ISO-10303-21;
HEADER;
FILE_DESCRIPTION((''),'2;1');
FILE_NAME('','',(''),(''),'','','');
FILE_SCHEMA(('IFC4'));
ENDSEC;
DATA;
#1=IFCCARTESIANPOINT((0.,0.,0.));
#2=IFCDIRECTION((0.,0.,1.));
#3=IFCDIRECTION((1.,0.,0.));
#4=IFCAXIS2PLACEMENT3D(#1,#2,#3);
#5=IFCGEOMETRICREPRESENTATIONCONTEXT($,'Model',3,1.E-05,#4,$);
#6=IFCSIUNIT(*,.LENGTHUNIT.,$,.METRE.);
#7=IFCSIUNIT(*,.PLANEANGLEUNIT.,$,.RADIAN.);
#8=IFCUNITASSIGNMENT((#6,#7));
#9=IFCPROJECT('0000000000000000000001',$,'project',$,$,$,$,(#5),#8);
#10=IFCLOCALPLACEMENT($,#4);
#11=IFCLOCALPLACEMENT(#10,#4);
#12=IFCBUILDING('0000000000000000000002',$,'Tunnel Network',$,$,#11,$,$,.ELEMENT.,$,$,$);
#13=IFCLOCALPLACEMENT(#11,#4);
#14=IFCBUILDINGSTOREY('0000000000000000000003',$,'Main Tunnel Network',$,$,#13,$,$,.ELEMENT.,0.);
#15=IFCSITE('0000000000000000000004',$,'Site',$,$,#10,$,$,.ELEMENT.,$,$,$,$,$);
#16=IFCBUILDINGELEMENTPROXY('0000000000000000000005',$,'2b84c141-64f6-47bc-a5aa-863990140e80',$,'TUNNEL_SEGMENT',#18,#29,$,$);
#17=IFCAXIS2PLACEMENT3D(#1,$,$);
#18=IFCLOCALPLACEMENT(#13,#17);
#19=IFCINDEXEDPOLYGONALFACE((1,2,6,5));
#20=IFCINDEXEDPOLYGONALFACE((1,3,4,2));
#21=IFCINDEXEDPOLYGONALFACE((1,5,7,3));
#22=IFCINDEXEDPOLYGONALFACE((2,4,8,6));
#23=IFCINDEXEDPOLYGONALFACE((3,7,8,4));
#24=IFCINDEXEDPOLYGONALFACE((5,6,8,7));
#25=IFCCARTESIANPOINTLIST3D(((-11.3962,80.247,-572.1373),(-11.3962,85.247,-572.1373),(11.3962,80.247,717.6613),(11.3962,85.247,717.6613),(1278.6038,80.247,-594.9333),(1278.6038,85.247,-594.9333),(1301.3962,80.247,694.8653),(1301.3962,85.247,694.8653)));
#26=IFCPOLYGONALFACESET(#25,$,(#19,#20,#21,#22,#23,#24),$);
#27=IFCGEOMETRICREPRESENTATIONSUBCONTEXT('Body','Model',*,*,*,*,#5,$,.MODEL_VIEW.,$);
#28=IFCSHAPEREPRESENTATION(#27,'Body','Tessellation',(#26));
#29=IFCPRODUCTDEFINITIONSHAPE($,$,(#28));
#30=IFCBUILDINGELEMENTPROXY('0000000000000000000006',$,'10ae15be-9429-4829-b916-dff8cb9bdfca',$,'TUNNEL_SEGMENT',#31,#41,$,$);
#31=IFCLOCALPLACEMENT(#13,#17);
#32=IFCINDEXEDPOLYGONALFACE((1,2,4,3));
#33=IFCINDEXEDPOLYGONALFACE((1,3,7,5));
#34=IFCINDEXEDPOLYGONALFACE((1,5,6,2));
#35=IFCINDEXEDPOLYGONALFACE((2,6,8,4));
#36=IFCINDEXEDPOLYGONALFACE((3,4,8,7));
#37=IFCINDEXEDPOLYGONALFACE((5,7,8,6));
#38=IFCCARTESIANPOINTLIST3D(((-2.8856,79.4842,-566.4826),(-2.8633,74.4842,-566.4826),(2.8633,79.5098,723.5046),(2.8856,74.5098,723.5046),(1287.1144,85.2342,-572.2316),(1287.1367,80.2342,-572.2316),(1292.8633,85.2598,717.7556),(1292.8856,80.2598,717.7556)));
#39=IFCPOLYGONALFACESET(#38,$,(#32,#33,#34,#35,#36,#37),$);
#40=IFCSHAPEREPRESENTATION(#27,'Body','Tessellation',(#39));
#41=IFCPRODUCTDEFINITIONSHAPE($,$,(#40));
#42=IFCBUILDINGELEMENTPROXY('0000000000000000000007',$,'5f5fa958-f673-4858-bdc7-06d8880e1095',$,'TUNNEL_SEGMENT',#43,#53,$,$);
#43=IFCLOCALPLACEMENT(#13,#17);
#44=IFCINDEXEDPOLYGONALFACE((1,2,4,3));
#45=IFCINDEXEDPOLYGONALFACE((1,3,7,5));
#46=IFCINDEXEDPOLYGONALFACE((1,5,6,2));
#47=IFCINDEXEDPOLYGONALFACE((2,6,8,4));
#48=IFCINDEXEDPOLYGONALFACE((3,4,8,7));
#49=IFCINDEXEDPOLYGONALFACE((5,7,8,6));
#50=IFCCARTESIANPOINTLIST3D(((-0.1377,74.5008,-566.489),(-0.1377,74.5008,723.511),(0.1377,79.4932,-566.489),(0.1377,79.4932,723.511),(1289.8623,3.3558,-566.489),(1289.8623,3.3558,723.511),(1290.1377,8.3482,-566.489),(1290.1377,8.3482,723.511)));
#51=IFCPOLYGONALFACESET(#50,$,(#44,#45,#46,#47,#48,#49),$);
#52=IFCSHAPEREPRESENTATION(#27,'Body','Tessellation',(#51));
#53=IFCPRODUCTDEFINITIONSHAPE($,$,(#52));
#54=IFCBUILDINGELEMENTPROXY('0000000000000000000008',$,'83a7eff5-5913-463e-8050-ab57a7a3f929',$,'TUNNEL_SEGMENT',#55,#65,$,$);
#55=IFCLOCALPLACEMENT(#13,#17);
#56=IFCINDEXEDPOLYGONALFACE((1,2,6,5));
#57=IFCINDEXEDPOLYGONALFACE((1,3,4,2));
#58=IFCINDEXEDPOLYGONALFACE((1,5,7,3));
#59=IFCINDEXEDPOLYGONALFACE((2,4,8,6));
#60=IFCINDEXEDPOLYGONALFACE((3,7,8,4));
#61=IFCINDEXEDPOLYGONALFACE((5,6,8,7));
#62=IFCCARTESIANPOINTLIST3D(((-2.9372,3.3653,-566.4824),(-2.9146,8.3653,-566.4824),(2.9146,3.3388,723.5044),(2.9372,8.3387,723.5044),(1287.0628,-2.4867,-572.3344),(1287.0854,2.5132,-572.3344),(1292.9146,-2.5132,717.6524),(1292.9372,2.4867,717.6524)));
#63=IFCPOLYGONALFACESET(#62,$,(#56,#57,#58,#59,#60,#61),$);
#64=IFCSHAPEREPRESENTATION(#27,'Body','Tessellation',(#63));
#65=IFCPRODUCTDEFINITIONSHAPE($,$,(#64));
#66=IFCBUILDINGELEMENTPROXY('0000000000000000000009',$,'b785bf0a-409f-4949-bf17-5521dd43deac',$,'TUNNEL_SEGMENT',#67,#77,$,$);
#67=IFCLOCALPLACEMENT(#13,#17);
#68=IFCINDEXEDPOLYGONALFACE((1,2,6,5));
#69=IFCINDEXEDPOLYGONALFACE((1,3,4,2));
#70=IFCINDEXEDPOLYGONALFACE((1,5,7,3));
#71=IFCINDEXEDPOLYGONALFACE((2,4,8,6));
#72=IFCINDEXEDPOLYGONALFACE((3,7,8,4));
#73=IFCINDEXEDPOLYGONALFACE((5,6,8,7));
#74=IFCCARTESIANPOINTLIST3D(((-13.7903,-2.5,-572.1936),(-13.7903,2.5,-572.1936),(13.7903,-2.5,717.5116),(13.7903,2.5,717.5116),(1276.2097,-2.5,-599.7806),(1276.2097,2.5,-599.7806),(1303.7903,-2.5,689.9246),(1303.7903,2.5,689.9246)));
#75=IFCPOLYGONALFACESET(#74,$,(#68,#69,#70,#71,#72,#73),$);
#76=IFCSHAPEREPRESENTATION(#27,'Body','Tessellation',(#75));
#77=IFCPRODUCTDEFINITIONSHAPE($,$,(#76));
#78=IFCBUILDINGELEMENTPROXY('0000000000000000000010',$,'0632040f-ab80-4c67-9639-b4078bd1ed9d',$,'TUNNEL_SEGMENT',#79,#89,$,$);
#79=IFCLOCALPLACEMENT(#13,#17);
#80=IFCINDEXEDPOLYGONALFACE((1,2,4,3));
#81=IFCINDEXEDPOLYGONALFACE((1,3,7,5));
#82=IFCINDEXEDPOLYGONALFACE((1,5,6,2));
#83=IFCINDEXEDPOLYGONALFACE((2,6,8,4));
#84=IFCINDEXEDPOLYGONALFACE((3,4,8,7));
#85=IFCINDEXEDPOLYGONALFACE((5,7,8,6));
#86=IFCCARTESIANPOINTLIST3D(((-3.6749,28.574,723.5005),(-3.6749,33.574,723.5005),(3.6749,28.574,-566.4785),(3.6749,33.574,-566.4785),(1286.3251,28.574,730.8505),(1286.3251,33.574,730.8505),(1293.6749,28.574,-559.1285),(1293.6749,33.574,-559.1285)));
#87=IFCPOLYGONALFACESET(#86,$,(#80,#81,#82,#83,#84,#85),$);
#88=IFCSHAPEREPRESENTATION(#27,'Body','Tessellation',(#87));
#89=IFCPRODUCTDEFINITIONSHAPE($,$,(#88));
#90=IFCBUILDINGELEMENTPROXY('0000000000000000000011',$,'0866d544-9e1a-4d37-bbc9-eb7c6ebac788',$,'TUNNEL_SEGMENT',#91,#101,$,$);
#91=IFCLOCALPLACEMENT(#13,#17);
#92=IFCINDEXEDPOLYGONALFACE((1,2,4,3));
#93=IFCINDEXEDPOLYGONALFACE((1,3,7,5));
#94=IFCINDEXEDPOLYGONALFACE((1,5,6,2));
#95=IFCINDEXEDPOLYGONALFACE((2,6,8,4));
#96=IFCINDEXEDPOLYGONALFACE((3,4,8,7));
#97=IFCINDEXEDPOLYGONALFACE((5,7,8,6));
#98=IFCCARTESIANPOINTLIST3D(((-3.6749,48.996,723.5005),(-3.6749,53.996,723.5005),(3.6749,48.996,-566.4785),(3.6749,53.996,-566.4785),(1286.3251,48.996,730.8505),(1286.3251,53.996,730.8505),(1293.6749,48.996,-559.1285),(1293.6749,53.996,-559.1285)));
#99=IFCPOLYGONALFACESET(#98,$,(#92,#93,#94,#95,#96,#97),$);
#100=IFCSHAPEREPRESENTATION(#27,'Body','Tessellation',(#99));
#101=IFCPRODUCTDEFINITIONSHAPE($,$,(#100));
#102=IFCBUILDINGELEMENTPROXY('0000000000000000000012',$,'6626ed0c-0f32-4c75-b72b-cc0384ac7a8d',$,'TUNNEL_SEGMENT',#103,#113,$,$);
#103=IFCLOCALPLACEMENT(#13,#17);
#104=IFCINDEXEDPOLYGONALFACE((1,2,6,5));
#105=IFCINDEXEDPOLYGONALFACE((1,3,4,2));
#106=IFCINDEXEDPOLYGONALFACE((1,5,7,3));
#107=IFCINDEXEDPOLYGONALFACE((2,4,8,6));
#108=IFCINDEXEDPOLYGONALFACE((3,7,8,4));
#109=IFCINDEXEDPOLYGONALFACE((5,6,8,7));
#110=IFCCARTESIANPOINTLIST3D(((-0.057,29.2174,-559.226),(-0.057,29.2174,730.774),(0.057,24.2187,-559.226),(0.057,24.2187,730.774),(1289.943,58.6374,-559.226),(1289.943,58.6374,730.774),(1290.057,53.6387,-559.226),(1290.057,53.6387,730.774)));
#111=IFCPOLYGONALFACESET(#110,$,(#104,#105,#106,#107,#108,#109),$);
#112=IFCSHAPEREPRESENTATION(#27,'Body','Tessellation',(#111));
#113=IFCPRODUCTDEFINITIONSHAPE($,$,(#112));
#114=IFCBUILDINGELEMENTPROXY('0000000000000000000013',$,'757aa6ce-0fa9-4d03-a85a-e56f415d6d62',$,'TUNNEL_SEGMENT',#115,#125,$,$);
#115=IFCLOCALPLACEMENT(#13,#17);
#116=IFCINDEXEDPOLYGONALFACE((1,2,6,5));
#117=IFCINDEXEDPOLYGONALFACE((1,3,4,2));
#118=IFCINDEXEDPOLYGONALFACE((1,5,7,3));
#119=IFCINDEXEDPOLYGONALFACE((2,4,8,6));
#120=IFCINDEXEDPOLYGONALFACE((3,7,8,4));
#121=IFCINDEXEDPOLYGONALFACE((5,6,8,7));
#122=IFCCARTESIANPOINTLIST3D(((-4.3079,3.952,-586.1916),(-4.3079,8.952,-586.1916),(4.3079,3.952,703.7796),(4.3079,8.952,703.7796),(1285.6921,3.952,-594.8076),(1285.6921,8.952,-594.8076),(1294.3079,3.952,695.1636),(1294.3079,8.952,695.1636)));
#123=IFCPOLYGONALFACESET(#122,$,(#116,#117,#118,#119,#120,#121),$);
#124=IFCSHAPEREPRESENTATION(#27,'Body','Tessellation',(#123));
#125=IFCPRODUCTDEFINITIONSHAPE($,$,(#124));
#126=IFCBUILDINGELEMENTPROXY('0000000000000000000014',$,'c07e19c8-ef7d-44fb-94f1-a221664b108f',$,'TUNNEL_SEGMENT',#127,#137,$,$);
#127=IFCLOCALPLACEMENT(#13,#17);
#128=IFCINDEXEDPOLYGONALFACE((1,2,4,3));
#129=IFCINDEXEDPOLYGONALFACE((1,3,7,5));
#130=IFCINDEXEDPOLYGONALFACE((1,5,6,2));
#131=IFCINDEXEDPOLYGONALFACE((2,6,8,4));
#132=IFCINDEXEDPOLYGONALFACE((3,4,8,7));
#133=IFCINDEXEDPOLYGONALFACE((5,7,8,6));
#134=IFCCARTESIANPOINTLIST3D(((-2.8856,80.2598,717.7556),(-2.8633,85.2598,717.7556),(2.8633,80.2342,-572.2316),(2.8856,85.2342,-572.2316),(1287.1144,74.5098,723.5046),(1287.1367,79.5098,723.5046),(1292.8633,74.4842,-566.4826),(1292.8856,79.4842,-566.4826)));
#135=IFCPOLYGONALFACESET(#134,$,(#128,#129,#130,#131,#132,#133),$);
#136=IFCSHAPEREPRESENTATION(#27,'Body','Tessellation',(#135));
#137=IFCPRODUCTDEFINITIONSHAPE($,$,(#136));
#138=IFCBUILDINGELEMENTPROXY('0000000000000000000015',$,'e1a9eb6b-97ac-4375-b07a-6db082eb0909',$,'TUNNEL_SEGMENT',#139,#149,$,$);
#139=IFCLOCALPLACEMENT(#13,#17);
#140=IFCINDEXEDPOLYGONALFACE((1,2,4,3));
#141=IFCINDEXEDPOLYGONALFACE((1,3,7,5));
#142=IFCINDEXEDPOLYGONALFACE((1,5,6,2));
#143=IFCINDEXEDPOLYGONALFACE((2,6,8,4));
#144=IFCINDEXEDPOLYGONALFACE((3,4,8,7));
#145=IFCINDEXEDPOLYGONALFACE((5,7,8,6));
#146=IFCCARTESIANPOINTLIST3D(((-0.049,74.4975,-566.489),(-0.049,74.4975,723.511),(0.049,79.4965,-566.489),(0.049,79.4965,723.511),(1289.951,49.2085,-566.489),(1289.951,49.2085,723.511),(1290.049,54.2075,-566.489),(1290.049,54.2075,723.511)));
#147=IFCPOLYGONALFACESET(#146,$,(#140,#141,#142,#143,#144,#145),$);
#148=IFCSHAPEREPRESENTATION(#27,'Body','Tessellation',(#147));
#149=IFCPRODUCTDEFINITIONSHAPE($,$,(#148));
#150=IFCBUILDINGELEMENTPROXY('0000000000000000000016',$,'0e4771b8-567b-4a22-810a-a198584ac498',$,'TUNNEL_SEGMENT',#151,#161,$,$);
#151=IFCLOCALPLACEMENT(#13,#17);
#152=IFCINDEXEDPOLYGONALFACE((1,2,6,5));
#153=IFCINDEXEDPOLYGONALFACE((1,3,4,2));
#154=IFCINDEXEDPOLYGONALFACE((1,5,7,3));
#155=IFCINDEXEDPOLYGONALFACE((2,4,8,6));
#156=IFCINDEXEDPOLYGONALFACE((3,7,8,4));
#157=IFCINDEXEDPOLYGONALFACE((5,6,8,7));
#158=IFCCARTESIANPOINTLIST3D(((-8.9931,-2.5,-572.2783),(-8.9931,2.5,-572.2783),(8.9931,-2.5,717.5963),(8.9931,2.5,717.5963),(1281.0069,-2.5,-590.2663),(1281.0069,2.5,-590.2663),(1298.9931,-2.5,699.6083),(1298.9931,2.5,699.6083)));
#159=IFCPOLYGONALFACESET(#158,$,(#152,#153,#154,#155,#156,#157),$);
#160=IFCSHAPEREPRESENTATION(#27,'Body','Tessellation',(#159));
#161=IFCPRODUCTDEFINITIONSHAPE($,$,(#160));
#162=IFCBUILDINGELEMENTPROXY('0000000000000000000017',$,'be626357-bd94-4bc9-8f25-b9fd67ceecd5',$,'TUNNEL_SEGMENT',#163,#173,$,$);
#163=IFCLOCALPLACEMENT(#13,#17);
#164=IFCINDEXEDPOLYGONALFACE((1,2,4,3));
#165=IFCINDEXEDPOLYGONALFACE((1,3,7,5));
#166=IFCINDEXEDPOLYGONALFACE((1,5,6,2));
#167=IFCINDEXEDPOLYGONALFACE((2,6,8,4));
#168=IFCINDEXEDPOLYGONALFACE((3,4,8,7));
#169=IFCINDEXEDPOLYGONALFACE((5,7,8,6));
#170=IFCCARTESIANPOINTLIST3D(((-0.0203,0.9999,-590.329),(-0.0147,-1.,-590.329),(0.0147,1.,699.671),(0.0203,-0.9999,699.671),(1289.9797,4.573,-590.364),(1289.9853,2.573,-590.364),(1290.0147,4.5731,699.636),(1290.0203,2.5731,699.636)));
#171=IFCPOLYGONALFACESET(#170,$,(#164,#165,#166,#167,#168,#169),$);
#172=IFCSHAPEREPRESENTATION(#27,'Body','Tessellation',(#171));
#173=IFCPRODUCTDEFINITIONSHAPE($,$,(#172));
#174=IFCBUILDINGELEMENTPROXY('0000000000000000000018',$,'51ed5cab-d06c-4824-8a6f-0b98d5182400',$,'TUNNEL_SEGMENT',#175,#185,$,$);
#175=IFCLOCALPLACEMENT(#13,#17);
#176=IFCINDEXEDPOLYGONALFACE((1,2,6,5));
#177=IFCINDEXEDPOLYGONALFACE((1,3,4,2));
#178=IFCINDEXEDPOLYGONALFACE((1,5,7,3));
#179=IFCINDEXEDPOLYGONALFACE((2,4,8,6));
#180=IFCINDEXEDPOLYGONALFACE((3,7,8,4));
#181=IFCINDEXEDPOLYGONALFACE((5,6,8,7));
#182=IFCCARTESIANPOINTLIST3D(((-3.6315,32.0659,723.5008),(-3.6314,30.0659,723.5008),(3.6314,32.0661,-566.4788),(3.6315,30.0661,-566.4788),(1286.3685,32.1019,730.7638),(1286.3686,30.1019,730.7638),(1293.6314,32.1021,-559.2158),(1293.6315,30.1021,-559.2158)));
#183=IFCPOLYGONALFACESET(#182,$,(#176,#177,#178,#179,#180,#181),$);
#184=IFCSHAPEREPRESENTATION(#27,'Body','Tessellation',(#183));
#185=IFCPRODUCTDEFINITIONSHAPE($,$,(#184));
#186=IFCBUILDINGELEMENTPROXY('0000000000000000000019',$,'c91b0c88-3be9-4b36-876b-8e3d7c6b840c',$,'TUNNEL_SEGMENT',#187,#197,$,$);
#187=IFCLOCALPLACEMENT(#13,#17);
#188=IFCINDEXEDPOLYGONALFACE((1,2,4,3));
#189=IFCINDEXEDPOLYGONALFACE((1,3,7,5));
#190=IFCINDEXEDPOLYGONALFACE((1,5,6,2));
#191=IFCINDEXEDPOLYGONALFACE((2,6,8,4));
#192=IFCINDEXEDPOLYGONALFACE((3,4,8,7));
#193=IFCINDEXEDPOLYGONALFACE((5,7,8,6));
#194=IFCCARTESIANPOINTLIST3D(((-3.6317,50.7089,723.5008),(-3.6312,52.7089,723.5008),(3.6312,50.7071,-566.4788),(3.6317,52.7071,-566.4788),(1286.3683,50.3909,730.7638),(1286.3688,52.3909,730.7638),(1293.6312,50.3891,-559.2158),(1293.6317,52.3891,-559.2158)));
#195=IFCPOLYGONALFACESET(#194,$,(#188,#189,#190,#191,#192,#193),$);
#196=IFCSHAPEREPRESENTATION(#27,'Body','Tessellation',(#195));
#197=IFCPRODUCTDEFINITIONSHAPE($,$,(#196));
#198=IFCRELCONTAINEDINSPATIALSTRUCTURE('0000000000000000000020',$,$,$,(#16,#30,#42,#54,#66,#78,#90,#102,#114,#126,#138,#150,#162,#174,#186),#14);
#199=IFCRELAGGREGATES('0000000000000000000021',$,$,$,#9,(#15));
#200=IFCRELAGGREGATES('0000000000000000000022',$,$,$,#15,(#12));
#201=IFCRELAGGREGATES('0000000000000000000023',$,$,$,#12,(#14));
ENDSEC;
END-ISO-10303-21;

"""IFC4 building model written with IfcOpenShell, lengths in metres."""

from ifc_helpers import new_model, si_unit, frame, origin_with_axes, origin_2d_with_axis, place, context, subcontext, project, spatial, rectangle, extrude, element, save


model = new_model("IFC4")

# Units and contexts
model_context = context("Model", 3, precision=1e-05, world=origin_with_axes())
body_context = subcontext(model_context, "Body", "Model", "MODEL_VIEW")
ifc_project = project(units=[si_unit("LENGTHUNIT", "METRE"), si_unit("PLANEANGLEUNIT", "RADIAN")], contexts=[model_context])

# Site, building, storey
site_placement = place(None, origin_with_axes())
site = spatial("IfcSite", under=ifc_project, at=site_placement, Name="Site", CompositionType="ELEMENT")
building_placement = place(site_placement, origin_with_axes())
building = spatial("IfcBuilding", under=site, at=building_placement, Name="Tunnel Network", CompositionType="ELEMENT")
storey_placement = place(building_placement, origin_with_axes())
storey = spatial("IfcBuildingStorey", under=building, at=storey_placement, Name="Main Tunnel Network", CompositionType="ELEMENT", Elevation=0.0)

# Building element proxies
proxy_1_placement = place(storey_placement, frame((0.0, 82.747, 72.762), z_axis=(0.999844, 0.0, -0.017669), x_axis=(0.017669, 0.0, 0.999844)))
element("IfcBuildingElementProxy", 1, at=proxy_1_placement, inside=storey, Name="2b84c141-64f6-47bc-a5aa-863990140e80", ObjectType="TUNNEL_SEGMENT", context=body_context, shape_type="SweptSolid", body=[
    extrude(rectangle(XDim=1290.0, YDim=5.0, at=origin_2d_with_axis()), origin_with_axes(), (0.0, 0.0, 1.0), 1290.2014),
])
proxy_2_placement = place(storey_placement, frame((0.0, 76.997, 78.511), z_axis=(0.99998, 0.004457, -0.004457), x_axis=(0.004456, 0.00002, 0.99999)))
element("IfcBuildingElementProxy", 2, at=proxy_2_placement, inside=storey, Name="10ae15be-9429-4829-b916-dff8cb9bdfca", ObjectType="TUNNEL_SEGMENT", context=body_context, shape_type="SweptSolid", body=[
    extrude(rectangle(XDim=1290.0, YDim=5.0, at=origin_2d_with_axis()), origin_with_axes(), (0.0, 0.0, 1.0), 1290.0256),
])
proxy_3_placement = place(storey_placement, frame((0.0, 76.997, 78.511), z_axis=(0.998483, -0.055067, 0.0), x_axis=(0.0, 0.0, 1.0)))
element("IfcBuildingElementProxy", 3, at=proxy_3_placement, inside=storey, Name="5f5fa958-f673-4858-bdc7-06d8880e1095", ObjectType="TUNNEL_SEGMENT", context=body_context, shape_type="SweptSolid", body=[
    extrude(rectangle(XDim=1290.0, YDim=5.0, at=origin_2d_with_axis()), origin_with_axes(), (0.0, 0.0, 1.0), 1291.9604),
])
proxy_4_placement = place(storey_placement, frame((0.0, 5.852, 78.511), z_axis=(0.999979, -0.004536, -0.004536), x_axis=(0.004536, -0.000021, 0.99999)))
element("IfcBuildingElementProxy", 4, at=proxy_4_placement, inside=storey, Name="83a7eff5-5913-463e-8050-ab57a7a3f929", ObjectType="TUNNEL_SEGMENT", context=body_context, shape_type="SweptSolid", body=[
    extrude(rectangle(XDim=1290.0, YDim=5.0, at=origin_2d_with_axis()), origin_with_axes(), (0.0, 0.0, 1.0), 1290.0265),
])
proxy_5_placement = place(storey_placement, frame((0.0, 0.0, 72.659), z_axis=(0.999771, 0.0, -0.02138), x_axis=(0.02138, 0.0, 0.999771)))
element("IfcBuildingElementProxy", 5, at=proxy_5_placement, inside=storey, Name="b785bf0a-409f-4949-bf17-5521dd43deac", ObjectType="TUNNEL_SEGMENT", context=body_context, shape_type="SweptSolid", body=[
    extrude(rectangle(XDim=1290.0, YDim=5.0, at=origin_2d_with_axis()), origin_with_axes(), (0.0, 0.0, 1.0), 1290.2949),
])
for number, where, z_axis, x_axis, name in (
    (6, (0.0, 31.074, 78.511), (0.999984, 0.0, 0.005698), (-0.005698, 0.0, 0.999984), "0632040f-ab80-4c67-9639-b4078bd1ed9d"),
    (7, (0.0, 51.496, 78.511), (0.999984, 0.0, 0.005698), (-0.005698, 0.0, 0.999984), "0866d544-9e1a-4d37-bbc9-eb7c6ebac788"),
):
    element("IfcBuildingElementProxy", number, at=place(storey_placement, frame(where, z_axis=z_axis, x_axis=x_axis)), inside=storey, Name=name, ObjectType="TUNNEL_SEGMENT", context=body_context, shape_type="SweptSolid", body=[
        extrude(rectangle(XDim=1290.0, YDim=5.0, at=origin_2d_with_axis()), origin_with_axes(), (0.0, 0.0, 1.0), 1290.0209),
    ])
proxy_6_placement = place(storey_placement, frame((0.0, 26.718, 85.774), z_axis=(0.99974, 0.0228, 0.0), x_axis=(0.0, 0.0, 1.0)))
element("IfcBuildingElementProxy", 8, at=proxy_6_placement, inside=storey, Name="6626ed0c-0f32-4c75-b72b-cc0384ac7a8d", ObjectType="TUNNEL_SEGMENT", context=body_context, shape_type="SweptSolid", body=[
    extrude(rectangle(XDim=1290.0, YDim=5.0, at=origin_2d_with_axis()), origin_with_axes(), (0.0, 0.0, 1.0), 1290.3354),
])
proxy_7_placement = place(storey_placement, frame((0.0, 6.452, 58.794), z_axis=(0.999978, 0.0, -0.006679), x_axis=(0.006679, 0.0, 0.999978)))
element("IfcBuildingElementProxy", 9, at=proxy_7_placement, inside=storey, Name="757aa6ce-0fa9-4d03-a85a-e56f415d6d62", ObjectType="TUNNEL_SEGMENT", context=body_context, shape_type="SweptSolid", body=[
    extrude(rectangle(XDim=1290.0, YDim=5.0, at=origin_2d_with_axis()), origin_with_axes(), (0.0, 0.0, 1.0), 1290.0288),
])
proxy_8_placement = place(storey_placement, frame((0.0, 82.747, 72.762), z_axis=(0.99998, -0.004457, 0.004457), x_axis=(-0.004456, 0.00002, 0.99999)))
element("IfcBuildingElementProxy", 10, at=proxy_8_placement, inside=storey, Name="c07e19c8-ef7d-44fb-94f1-a221664b108f", ObjectType="TUNNEL_SEGMENT", context=body_context, shape_type="SweptSolid", body=[
    extrude(rectangle(XDim=1290.0, YDim=5.0, at=origin_2d_with_axis()), origin_with_axes(), (0.0, 0.0, 1.0), 1290.0256),
])
proxy_9_placement = place(storey_placement, frame((0.0, 76.997, 78.511), z_axis=(0.999808, -0.0196, 0.0), x_axis=(0.0, 0.0, 1.0)))
element("IfcBuildingElementProxy", 11, at=proxy_9_placement, inside=storey, Name="e1a9eb6b-97ac-4375-b07a-6db082eb0909", ObjectType="TUNNEL_SEGMENT", context=body_context, shape_type="SweptSolid", body=[
    extrude(rectangle(XDim=1290.0, YDim=5.0, at=origin_2d_with_axis()), origin_with_axes(), (0.0, 0.0, 1.0), 1290.2479),
])
proxy_10_placement = place(storey_placement, frame((0.0, 0.0, 72.659), z_axis=(0.999903, 0.0, -0.013943), x_axis=(0.013943, 0.0, 0.999903)))
element("IfcBuildingElementProxy", 12, at=proxy_10_placement, inside=storey, Name="0e4771b8-567b-4a22-810a-a198584ac498", ObjectType="TUNNEL_SEGMENT", context=body_context, shape_type="SweptSolid", body=[
    extrude(rectangle(XDim=1290.0, YDim=5.0, at=origin_2d_with_axis()), origin_with_axes(), (0.0, 0.0, 1.0), 1290.1254),
])
proxy_11_placement = place(storey_placement, frame((0.0, 0.0, 54.671), z_axis=(0.999996, 0.00277, -0.000027), x_axis=(0.000027, 0.0, 1.0)))
element("IfcBuildingElementProxy", 13, at=proxy_11_placement, inside=storey, Name="be626357-bd94-4bc9-8f25-b9fd67ceecd5", ObjectType="TUNNEL_SEGMENT", context=body_context, shape_type="SweptSolid", body=[
    extrude(rectangle(XDim=1290.0, YDim=2.0, at=origin_2d_with_axis()), origin_with_axes(), (0.0, 0.0, 1.0), 1290.0049),
])
proxy_12_placement = place(storey_placement, frame((0.0, 31.066, 78.511), z_axis=(0.999984, 0.000028, 0.00563), x_axis=(-0.00563, 0.0, 0.999984)))
element("IfcBuildingElementProxy", 14, at=proxy_12_placement, inside=storey, Name="51ed5cab-d06c-4824-8a6f-0b98d5182400", ObjectType="TUNNEL_SEGMENT", context=body_context, shape_type="SweptSolid", body=[
    extrude(rectangle(XDim=1290.0, YDim=2.0, at=origin_2d_with_axis()), origin_with_axes(), (0.0, 0.0, 1.0), 1290.0204),
])
proxy_13_placement = place(storey_placement, frame((0.0, 51.708, 78.511), z_axis=(0.999984, -0.000247, 0.00563), x_axis=(-0.00563, 0.000001, 0.999984)))
element("IfcBuildingElementProxy", 15, at=proxy_13_placement, inside=storey, Name="c91b0c88-3be9-4b36-876b-8e3d7c6b840c", ObjectType="TUNNEL_SEGMENT", context=body_context, shape_type="SweptSolid", body=[
    extrude(rectangle(XDim=1290.0, YDim=2.0, at=origin_2d_with_axis()), origin_with_axes(), (0.0, 0.0, 1.0), 1290.0205),
])

save(model, "model.ifc")
